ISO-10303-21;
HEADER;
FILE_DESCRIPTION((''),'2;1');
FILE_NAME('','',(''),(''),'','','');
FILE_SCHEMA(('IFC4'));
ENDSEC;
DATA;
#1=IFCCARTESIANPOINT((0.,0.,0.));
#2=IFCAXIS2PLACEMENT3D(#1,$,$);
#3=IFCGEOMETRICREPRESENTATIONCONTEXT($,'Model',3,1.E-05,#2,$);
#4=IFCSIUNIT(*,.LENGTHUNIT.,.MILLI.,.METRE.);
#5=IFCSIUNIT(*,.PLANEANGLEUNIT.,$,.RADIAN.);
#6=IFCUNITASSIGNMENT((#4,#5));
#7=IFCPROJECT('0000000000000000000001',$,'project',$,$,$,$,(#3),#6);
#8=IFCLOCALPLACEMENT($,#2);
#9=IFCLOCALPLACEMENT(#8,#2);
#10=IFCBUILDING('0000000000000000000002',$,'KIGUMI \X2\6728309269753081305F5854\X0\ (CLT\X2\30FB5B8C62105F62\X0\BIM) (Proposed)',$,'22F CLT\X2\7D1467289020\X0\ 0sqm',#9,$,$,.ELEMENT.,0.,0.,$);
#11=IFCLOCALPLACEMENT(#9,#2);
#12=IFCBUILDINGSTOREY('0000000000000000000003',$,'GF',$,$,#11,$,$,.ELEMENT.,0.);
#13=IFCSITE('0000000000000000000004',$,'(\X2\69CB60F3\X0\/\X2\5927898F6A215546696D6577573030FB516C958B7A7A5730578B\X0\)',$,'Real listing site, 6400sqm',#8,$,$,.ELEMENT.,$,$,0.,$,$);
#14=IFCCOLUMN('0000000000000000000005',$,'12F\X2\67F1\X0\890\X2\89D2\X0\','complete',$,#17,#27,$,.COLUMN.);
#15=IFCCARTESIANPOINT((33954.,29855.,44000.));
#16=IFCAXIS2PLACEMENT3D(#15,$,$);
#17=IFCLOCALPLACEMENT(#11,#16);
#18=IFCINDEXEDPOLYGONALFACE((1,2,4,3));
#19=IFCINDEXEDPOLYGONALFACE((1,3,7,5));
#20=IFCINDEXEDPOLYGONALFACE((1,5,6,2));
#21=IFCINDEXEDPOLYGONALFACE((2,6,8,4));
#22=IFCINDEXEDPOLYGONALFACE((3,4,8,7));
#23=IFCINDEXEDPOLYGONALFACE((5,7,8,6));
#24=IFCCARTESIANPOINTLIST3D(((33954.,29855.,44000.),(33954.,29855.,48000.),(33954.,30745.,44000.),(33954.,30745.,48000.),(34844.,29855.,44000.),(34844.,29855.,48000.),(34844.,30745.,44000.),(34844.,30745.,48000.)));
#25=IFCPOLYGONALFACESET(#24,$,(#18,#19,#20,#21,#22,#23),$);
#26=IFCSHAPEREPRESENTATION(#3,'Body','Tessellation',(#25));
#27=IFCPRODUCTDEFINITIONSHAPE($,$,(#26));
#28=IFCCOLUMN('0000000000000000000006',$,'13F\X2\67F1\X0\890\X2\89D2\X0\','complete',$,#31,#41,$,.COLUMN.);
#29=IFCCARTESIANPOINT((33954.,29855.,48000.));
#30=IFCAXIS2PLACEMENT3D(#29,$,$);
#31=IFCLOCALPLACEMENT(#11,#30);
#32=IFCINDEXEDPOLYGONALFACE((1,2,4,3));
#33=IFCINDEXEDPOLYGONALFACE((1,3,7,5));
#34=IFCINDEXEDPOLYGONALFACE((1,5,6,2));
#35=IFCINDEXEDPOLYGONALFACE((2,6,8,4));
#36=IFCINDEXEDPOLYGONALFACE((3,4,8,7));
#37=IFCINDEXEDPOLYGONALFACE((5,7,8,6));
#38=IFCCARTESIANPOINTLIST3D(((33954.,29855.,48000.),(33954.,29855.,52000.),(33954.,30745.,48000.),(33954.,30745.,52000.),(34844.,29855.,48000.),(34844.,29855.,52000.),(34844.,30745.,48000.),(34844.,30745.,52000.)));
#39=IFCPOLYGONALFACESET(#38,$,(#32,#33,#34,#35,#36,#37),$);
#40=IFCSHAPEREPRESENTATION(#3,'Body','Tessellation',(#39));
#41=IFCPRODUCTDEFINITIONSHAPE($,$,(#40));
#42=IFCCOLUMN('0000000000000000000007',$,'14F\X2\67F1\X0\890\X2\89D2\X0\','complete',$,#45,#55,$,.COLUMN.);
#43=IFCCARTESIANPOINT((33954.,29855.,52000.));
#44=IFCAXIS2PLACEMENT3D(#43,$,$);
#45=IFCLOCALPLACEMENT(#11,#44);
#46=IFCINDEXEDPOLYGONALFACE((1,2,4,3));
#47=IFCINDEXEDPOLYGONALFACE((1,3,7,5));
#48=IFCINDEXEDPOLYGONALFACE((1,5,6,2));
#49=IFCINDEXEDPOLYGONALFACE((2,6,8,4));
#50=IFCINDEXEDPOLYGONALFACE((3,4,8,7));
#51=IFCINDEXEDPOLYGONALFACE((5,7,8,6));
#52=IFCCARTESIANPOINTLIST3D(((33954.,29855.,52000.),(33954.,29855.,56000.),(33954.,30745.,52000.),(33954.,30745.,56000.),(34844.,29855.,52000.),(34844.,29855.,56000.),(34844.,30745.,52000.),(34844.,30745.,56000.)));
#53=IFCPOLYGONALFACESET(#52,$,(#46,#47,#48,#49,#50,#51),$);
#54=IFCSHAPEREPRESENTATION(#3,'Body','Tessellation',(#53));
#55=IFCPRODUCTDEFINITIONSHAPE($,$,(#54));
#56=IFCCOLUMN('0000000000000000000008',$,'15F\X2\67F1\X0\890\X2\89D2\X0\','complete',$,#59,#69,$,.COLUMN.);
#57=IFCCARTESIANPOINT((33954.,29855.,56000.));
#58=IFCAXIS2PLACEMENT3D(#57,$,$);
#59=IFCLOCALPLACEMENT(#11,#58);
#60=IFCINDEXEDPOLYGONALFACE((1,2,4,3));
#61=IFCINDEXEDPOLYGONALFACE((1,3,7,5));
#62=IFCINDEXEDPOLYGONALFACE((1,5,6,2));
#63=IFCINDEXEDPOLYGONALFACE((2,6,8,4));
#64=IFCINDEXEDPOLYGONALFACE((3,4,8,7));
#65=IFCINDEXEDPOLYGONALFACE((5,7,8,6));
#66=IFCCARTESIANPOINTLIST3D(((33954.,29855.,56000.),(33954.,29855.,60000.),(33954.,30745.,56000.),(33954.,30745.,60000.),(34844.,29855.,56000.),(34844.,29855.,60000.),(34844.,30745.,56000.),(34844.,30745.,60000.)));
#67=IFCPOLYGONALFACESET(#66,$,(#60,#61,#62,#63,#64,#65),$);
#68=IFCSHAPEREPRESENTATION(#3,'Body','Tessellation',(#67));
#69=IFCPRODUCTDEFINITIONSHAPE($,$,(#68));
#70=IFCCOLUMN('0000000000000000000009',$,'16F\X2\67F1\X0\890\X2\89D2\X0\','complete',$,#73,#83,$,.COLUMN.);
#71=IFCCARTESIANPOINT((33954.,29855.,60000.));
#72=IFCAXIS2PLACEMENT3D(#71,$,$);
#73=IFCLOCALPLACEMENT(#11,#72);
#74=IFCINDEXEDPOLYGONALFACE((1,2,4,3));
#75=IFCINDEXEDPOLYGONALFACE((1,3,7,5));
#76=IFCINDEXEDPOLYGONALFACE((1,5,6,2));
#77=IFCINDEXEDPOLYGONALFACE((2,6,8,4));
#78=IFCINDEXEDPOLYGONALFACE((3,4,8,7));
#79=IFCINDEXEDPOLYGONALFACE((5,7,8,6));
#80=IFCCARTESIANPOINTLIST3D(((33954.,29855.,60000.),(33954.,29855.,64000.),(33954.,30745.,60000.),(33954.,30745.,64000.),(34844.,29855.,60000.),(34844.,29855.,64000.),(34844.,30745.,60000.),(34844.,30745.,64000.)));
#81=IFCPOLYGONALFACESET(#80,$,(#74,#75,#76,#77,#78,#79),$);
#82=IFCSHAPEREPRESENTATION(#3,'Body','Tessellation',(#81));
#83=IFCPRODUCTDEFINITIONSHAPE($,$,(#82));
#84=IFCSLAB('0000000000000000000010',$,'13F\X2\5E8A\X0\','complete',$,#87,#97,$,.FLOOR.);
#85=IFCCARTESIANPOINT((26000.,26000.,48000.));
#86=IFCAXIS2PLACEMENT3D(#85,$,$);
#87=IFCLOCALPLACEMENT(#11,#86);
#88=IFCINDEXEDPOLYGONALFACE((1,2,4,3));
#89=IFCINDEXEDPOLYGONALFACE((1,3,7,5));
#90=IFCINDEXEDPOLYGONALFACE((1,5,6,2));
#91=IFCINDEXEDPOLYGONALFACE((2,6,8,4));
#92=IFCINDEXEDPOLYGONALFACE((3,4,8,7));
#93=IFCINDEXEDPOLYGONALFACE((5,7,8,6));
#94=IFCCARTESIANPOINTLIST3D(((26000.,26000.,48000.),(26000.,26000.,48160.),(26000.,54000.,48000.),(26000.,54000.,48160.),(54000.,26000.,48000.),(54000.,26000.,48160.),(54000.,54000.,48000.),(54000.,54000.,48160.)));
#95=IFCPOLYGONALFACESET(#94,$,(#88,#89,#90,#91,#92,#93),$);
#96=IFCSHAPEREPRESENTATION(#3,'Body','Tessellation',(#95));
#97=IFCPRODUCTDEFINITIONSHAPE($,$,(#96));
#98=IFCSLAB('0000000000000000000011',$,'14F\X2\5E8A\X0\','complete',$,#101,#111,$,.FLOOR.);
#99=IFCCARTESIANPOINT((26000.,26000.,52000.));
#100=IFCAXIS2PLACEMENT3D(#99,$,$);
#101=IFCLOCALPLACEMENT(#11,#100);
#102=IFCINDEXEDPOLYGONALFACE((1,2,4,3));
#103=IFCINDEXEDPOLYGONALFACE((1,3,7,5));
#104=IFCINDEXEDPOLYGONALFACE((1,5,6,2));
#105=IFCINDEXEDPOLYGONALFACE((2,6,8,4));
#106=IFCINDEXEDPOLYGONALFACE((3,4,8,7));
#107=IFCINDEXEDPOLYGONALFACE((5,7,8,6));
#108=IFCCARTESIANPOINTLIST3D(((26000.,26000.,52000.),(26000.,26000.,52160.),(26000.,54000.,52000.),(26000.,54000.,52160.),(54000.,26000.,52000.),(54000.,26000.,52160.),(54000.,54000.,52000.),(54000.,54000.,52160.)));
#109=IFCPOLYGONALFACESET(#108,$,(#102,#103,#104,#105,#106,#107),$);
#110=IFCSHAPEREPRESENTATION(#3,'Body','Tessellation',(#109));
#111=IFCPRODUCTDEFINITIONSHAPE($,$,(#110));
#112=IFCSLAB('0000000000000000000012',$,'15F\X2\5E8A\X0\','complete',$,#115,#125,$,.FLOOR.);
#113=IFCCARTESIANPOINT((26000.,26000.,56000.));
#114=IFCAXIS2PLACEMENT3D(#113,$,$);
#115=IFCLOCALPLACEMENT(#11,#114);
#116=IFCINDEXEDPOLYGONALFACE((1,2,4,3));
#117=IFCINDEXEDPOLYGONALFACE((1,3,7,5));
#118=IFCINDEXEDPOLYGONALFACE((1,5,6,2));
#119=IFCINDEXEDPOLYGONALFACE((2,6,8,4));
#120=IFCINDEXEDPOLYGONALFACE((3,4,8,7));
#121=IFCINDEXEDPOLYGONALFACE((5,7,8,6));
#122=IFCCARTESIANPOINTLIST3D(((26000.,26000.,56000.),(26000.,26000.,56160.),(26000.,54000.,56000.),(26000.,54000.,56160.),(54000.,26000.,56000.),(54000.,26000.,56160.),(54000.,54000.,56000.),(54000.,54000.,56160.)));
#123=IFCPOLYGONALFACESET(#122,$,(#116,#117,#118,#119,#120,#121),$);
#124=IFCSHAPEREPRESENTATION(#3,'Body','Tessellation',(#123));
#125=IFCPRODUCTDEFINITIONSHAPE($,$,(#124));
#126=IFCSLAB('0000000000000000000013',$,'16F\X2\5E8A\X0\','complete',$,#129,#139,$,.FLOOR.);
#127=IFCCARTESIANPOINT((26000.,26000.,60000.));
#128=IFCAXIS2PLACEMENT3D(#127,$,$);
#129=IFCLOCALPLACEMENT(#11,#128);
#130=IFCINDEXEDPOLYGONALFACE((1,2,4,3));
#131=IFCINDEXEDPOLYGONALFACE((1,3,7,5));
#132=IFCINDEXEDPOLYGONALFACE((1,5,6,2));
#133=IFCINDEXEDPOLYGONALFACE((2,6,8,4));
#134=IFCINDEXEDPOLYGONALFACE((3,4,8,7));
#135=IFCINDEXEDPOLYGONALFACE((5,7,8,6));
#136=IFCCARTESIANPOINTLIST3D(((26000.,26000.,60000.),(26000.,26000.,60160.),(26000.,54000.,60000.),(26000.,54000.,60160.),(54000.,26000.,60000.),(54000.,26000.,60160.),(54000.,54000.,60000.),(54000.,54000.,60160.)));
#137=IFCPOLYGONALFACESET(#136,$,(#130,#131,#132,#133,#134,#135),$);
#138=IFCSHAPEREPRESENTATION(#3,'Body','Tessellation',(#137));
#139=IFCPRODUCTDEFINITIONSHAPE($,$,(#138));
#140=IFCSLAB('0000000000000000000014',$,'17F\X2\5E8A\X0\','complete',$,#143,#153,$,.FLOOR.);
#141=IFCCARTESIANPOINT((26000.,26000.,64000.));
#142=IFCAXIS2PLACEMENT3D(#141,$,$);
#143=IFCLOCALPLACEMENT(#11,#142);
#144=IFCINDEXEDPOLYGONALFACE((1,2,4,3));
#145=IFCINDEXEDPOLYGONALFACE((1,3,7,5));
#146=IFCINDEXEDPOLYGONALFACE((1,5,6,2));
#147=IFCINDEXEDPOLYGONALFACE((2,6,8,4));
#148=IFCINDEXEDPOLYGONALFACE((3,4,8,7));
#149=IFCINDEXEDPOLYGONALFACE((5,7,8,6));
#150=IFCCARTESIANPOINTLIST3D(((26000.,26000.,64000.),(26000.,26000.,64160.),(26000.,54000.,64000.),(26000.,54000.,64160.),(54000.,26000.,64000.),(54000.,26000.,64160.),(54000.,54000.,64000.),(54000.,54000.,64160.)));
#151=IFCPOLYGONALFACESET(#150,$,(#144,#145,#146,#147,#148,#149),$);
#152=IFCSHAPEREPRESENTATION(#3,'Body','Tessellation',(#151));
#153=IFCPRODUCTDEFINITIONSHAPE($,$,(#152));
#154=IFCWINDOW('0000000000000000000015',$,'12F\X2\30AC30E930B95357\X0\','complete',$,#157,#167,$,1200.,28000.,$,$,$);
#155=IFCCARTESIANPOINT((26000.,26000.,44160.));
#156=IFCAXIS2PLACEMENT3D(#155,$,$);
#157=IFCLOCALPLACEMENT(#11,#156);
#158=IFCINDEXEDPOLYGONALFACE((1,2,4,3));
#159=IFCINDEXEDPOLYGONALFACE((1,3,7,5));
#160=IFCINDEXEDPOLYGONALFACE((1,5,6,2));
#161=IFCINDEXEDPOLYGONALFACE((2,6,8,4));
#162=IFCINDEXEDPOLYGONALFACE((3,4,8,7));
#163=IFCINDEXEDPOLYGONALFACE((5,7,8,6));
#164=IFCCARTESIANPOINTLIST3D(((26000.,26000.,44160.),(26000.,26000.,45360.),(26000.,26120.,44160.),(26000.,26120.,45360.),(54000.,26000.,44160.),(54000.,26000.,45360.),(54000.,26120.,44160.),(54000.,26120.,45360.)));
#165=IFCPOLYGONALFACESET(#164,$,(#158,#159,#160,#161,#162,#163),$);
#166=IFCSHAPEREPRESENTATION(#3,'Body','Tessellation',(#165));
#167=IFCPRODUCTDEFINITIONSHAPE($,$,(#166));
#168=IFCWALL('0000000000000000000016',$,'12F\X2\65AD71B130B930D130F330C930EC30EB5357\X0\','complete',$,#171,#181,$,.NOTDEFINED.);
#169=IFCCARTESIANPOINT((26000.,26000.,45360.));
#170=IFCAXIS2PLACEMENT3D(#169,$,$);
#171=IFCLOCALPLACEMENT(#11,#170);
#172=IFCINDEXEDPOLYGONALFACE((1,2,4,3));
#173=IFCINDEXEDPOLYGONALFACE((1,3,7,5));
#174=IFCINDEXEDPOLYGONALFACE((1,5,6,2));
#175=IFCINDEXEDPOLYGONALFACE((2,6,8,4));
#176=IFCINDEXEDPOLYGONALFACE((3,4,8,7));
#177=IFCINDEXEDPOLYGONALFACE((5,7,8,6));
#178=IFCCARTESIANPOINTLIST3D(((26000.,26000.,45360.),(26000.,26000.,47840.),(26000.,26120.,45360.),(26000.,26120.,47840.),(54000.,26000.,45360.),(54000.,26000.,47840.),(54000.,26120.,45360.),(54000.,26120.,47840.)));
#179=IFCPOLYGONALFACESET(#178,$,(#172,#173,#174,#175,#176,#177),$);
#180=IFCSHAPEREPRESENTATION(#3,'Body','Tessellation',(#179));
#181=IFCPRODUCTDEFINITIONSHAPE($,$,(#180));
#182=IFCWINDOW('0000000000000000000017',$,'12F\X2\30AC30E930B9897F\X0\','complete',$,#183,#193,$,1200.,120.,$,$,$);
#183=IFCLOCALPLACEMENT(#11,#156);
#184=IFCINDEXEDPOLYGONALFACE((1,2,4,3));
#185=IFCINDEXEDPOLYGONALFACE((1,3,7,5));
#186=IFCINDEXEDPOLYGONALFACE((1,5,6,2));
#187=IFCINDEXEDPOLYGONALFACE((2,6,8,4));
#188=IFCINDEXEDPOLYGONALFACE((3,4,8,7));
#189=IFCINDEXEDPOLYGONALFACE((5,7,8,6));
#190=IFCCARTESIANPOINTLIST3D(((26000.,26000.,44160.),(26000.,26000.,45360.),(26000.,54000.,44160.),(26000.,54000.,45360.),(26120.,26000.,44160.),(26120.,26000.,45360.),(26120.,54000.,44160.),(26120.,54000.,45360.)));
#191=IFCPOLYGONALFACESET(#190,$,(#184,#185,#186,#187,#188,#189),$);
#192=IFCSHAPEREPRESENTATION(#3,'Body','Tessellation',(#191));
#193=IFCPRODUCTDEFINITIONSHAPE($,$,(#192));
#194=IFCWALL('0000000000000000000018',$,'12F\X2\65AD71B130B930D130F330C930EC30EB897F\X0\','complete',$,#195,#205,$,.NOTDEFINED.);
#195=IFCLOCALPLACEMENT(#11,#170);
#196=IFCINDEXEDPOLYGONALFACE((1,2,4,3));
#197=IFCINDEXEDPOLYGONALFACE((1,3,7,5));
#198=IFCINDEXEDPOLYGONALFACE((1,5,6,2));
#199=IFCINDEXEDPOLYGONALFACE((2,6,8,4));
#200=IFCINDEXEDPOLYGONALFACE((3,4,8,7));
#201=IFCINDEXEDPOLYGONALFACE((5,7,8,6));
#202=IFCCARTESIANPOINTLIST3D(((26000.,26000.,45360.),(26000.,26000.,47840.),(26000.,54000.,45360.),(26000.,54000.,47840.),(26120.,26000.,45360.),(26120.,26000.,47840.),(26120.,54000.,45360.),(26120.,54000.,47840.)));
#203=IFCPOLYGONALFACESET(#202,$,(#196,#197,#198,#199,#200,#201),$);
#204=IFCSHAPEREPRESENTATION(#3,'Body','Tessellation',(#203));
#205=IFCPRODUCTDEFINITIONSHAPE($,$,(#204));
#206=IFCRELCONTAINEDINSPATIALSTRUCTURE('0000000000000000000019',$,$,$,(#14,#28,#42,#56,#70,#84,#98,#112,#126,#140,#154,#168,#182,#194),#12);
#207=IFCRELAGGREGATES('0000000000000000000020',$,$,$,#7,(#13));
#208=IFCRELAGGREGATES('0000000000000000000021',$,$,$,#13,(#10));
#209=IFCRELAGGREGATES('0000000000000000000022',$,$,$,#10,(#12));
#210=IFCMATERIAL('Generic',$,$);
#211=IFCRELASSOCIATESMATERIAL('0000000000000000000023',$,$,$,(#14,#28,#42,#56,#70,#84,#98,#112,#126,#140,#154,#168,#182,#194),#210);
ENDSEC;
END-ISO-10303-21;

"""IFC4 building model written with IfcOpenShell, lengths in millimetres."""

from ifc_helpers import new_model, si_unit, frame, frame_2d, origin, place, context, project, spatial, rectangle, extrude, material, element, save


model = new_model("IFC4")

# Units and contexts
model_context = context("Model", 3, precision=1e-05, world=origin())
ifc_project = project(units=[si_unit("LENGTHUNIT", "METRE", prefix="MILLI"), si_unit("PLANEANGLEUNIT", "RADIAN")], contexts=[model_context])

# Site, building, storey
site_placement = place(None, origin())
site = spatial("IfcSite", under=ifc_project, at=site_placement, Name="(構想/大規模商業敷地・公開空地型)", ObjectType="Real listing site, 6400sqm", CompositionType="ELEMENT", RefElevation=0.0)
building_placement = place(site_placement, origin())
building = spatial("IfcBuilding", under=site, at=building_placement, Name="KIGUMI 木を極めた塔 (CLT・完成形BIM) (Proposed)", ObjectType="22F CLT純木造 0sqm", CompositionType="ELEMENT", ElevationOfRefHeight=0.0, ElevationOfTerrain=0.0)
storey_placement = place(building_placement, origin())
storey = spatial("IfcBuildingStorey", under=building, at=storey_placement, Name="GF", CompositionType="ELEMENT", Elevation=0.0)

# Columns
ifc_material = material(Name="Generic")
column_1_placement = place(storey_placement, frame((33954.0, 29855.0, 44000.0)))
element("IfcColumn", 1, at=column_1_placement, inside=storey, material=ifc_material, Name="12F柱890角", Description="complete", PredefinedType="COLUMN", context=model_context, shape_type="SweptSolid", body=[
    extrude(rectangle(XDim=890.0, YDim=890.0, at=frame_2d((445.0, 445.0))), frame((33954.0, 29855.0, 44000.0)), (0.0, 0.0, 1.0), 4000.0),
])
column_2_placement = place(storey_placement, frame((33954.0, 29855.0, 48000.0)))
element("IfcColumn", 2, at=column_2_placement, inside=storey, material=ifc_material, Name="13F柱890角", Description="complete", PredefinedType="COLUMN", context=model_context, shape_type="SweptSolid", body=[
    extrude(rectangle(XDim=890.0, YDim=890.0, at=frame_2d((445.0, 445.0))), frame((33954.0, 29855.0, 48000.0)), (0.0, 0.0, 1.0), 4000.0),
])
column_3_placement = place(storey_placement, frame((33954.0, 29855.0, 52000.0)))
element("IfcColumn", 3, at=column_3_placement, inside=storey, material=ifc_material, Name="14F柱890角", Description="complete", PredefinedType="COLUMN", context=model_context, shape_type="SweptSolid", body=[
    extrude(rectangle(XDim=890.0, YDim=890.0, at=frame_2d((445.0, 445.0))), frame((33954.0, 29855.0, 52000.0)), (0.0, 0.0, 1.0), 4000.0),
])
column_4_placement = place(storey_placement, frame((33954.0, 29855.0, 56000.0)))
element("IfcColumn", 4, at=column_4_placement, inside=storey, material=ifc_material, Name="15F柱890角", Description="complete", PredefinedType="COLUMN", context=model_context, shape_type="SweptSolid", body=[
    extrude(rectangle(XDim=890.0, YDim=890.0, at=frame_2d((445.0, 445.0))), frame((33954.0, 29855.0, 56000.0)), (0.0, 0.0, 1.0), 4000.0),
])
column_5_placement = place(storey_placement, frame((33954.0, 29855.0, 60000.0)))
element("IfcColumn", 5, at=column_5_placement, inside=storey, material=ifc_material, Name="16F柱890角", Description="complete", PredefinedType="COLUMN", context=model_context, shape_type="SweptSolid", body=[
    extrude(rectangle(XDim=890.0, YDim=890.0, at=frame_2d((445.0, 445.0))), frame((33954.0, 29855.0, 60000.0)), (0.0, 0.0, 1.0), 4000.0),
])

# Slabs
slab_1_placement = place(storey_placement, frame((26000.0, 26000.0, 48000.0)))
element("IfcSlab", 6, at=slab_1_placement, inside=storey, material=ifc_material, Name="13F床", Description="complete", PredefinedType="FLOOR", context=model_context, shape_type="SweptSolid", body=[
    extrude(rectangle(XDim=28000.0, YDim=28000.0, at=frame_2d((14000.0, 14000.0))), frame((26000.0, 26000.0, 48000.0)), (0.0, 0.0, 1.0), 160.0),
])
slab_2_placement = place(storey_placement, frame((26000.0, 26000.0, 52000.0)))
element("IfcSlab", 7, at=slab_2_placement, inside=storey, material=ifc_material, Name="14F床", Description="complete", PredefinedType="FLOOR", context=model_context, shape_type="SweptSolid", body=[
    extrude(rectangle(XDim=28000.0, YDim=28000.0, at=frame_2d((14000.0, 14000.0))), frame((26000.0, 26000.0, 52000.0)), (0.0, 0.0, 1.0), 160.0),
])
slab_3_placement = place(storey_placement, frame((26000.0, 26000.0, 56000.0)))
element("IfcSlab", 8, at=slab_3_placement, inside=storey, material=ifc_material, Name="15F床", Description="complete", PredefinedType="FLOOR", context=model_context, shape_type="SweptSolid", body=[
    extrude(rectangle(XDim=28000.0, YDim=28000.0, at=frame_2d((14000.0, 14000.0))), frame((26000.0, 26000.0, 56000.0)), (0.0, 0.0, 1.0), 160.0),
])
slab_4_placement = place(storey_placement, frame((26000.0, 26000.0, 60000.0)))
element("IfcSlab", 9, at=slab_4_placement, inside=storey, material=ifc_material, Name="16F床", Description="complete", PredefinedType="FLOOR", context=model_context, shape_type="SweptSolid", body=[
    extrude(rectangle(XDim=28000.0, YDim=28000.0, at=frame_2d((14000.0, 14000.0))), frame((26000.0, 26000.0, 60000.0)), (0.0, 0.0, 1.0), 160.0),
])
slab_5_placement = place(storey_placement, frame((26000.0, 26000.0, 64000.0)))
element("IfcSlab", 10, at=slab_5_placement, inside=storey, material=ifc_material, Name="17F床", Description="complete", PredefinedType="FLOOR", context=model_context, shape_type="SweptSolid", body=[
    extrude(rectangle(XDim=28000.0, YDim=28000.0, at=frame_2d((14000.0, 14000.0))), frame((26000.0, 26000.0, 64000.0)), (0.0, 0.0, 1.0), 160.0),
])

# Window
window_1_placement = place(storey_placement, frame((26000.0, 26000.0, 44160.0)))
element("IfcWindow", 11, at=window_1_placement, inside=storey, material=ifc_material, Name="12Fガラス南", Description="complete", OverallHeight=1200.0, OverallWidth=28000.0, context=model_context, shape_type="SweptSolid", body=[
    extrude(rectangle(XDim=28000.0, YDim=120.0, at=frame_2d((14000.0, 60.0))), frame((26000.0, 26000.0, 44160.0)), (0.0, 0.0, 1.0), 1200.0),
])

# Wall
wall_1_placement = place(storey_placement, frame((26000.0, 26000.0, 45360.0)))
element("IfcWall", 12, at=wall_1_placement, inside=storey, material=ifc_material, Name="12F断熱スパンドレル南", Description="complete", PredefinedType="NOTDEFINED", context=model_context, shape_type="SweptSolid", body=[
    extrude(rectangle(XDim=28000.0, YDim=120.0, at=frame_2d((14000.0, 60.0))), frame((26000.0, 26000.0, 45360.0)), (0.0, 0.0, 1.0), 2480.0),
])

# Window
window_2_placement = place(storey_placement, frame((26000.0, 26000.0, 44160.0)))
element("IfcWindow", 13, at=window_2_placement, inside=storey, material=ifc_material, Name="12Fガラス西", Description="complete", OverallHeight=1200.0, OverallWidth=120.0, context=model_context, shape_type="SweptSolid", body=[
    extrude(rectangle(XDim=120.0, YDim=28000.0, at=frame_2d((60.0, 14000.0))), frame((26000.0, 26000.0, 44160.0)), (0.0, 0.0, 1.0), 1200.0),
])

# Wall
wall_2_placement = place(storey_placement, frame((26000.0, 26000.0, 45360.0)))
element("IfcWall", 14, at=wall_2_placement, inside=storey, material=ifc_material, Name="12F断熱スパンドレル西", Description="complete", PredefinedType="NOTDEFINED", context=model_context, shape_type="SweptSolid", body=[
    extrude(rectangle(XDim=120.0, YDim=28000.0, at=frame_2d((60.0, 14000.0))), frame((26000.0, 26000.0, 45360.0)), (0.0, 0.0, 1.0), 2480.0),
])

save(model, "model.ifc")
